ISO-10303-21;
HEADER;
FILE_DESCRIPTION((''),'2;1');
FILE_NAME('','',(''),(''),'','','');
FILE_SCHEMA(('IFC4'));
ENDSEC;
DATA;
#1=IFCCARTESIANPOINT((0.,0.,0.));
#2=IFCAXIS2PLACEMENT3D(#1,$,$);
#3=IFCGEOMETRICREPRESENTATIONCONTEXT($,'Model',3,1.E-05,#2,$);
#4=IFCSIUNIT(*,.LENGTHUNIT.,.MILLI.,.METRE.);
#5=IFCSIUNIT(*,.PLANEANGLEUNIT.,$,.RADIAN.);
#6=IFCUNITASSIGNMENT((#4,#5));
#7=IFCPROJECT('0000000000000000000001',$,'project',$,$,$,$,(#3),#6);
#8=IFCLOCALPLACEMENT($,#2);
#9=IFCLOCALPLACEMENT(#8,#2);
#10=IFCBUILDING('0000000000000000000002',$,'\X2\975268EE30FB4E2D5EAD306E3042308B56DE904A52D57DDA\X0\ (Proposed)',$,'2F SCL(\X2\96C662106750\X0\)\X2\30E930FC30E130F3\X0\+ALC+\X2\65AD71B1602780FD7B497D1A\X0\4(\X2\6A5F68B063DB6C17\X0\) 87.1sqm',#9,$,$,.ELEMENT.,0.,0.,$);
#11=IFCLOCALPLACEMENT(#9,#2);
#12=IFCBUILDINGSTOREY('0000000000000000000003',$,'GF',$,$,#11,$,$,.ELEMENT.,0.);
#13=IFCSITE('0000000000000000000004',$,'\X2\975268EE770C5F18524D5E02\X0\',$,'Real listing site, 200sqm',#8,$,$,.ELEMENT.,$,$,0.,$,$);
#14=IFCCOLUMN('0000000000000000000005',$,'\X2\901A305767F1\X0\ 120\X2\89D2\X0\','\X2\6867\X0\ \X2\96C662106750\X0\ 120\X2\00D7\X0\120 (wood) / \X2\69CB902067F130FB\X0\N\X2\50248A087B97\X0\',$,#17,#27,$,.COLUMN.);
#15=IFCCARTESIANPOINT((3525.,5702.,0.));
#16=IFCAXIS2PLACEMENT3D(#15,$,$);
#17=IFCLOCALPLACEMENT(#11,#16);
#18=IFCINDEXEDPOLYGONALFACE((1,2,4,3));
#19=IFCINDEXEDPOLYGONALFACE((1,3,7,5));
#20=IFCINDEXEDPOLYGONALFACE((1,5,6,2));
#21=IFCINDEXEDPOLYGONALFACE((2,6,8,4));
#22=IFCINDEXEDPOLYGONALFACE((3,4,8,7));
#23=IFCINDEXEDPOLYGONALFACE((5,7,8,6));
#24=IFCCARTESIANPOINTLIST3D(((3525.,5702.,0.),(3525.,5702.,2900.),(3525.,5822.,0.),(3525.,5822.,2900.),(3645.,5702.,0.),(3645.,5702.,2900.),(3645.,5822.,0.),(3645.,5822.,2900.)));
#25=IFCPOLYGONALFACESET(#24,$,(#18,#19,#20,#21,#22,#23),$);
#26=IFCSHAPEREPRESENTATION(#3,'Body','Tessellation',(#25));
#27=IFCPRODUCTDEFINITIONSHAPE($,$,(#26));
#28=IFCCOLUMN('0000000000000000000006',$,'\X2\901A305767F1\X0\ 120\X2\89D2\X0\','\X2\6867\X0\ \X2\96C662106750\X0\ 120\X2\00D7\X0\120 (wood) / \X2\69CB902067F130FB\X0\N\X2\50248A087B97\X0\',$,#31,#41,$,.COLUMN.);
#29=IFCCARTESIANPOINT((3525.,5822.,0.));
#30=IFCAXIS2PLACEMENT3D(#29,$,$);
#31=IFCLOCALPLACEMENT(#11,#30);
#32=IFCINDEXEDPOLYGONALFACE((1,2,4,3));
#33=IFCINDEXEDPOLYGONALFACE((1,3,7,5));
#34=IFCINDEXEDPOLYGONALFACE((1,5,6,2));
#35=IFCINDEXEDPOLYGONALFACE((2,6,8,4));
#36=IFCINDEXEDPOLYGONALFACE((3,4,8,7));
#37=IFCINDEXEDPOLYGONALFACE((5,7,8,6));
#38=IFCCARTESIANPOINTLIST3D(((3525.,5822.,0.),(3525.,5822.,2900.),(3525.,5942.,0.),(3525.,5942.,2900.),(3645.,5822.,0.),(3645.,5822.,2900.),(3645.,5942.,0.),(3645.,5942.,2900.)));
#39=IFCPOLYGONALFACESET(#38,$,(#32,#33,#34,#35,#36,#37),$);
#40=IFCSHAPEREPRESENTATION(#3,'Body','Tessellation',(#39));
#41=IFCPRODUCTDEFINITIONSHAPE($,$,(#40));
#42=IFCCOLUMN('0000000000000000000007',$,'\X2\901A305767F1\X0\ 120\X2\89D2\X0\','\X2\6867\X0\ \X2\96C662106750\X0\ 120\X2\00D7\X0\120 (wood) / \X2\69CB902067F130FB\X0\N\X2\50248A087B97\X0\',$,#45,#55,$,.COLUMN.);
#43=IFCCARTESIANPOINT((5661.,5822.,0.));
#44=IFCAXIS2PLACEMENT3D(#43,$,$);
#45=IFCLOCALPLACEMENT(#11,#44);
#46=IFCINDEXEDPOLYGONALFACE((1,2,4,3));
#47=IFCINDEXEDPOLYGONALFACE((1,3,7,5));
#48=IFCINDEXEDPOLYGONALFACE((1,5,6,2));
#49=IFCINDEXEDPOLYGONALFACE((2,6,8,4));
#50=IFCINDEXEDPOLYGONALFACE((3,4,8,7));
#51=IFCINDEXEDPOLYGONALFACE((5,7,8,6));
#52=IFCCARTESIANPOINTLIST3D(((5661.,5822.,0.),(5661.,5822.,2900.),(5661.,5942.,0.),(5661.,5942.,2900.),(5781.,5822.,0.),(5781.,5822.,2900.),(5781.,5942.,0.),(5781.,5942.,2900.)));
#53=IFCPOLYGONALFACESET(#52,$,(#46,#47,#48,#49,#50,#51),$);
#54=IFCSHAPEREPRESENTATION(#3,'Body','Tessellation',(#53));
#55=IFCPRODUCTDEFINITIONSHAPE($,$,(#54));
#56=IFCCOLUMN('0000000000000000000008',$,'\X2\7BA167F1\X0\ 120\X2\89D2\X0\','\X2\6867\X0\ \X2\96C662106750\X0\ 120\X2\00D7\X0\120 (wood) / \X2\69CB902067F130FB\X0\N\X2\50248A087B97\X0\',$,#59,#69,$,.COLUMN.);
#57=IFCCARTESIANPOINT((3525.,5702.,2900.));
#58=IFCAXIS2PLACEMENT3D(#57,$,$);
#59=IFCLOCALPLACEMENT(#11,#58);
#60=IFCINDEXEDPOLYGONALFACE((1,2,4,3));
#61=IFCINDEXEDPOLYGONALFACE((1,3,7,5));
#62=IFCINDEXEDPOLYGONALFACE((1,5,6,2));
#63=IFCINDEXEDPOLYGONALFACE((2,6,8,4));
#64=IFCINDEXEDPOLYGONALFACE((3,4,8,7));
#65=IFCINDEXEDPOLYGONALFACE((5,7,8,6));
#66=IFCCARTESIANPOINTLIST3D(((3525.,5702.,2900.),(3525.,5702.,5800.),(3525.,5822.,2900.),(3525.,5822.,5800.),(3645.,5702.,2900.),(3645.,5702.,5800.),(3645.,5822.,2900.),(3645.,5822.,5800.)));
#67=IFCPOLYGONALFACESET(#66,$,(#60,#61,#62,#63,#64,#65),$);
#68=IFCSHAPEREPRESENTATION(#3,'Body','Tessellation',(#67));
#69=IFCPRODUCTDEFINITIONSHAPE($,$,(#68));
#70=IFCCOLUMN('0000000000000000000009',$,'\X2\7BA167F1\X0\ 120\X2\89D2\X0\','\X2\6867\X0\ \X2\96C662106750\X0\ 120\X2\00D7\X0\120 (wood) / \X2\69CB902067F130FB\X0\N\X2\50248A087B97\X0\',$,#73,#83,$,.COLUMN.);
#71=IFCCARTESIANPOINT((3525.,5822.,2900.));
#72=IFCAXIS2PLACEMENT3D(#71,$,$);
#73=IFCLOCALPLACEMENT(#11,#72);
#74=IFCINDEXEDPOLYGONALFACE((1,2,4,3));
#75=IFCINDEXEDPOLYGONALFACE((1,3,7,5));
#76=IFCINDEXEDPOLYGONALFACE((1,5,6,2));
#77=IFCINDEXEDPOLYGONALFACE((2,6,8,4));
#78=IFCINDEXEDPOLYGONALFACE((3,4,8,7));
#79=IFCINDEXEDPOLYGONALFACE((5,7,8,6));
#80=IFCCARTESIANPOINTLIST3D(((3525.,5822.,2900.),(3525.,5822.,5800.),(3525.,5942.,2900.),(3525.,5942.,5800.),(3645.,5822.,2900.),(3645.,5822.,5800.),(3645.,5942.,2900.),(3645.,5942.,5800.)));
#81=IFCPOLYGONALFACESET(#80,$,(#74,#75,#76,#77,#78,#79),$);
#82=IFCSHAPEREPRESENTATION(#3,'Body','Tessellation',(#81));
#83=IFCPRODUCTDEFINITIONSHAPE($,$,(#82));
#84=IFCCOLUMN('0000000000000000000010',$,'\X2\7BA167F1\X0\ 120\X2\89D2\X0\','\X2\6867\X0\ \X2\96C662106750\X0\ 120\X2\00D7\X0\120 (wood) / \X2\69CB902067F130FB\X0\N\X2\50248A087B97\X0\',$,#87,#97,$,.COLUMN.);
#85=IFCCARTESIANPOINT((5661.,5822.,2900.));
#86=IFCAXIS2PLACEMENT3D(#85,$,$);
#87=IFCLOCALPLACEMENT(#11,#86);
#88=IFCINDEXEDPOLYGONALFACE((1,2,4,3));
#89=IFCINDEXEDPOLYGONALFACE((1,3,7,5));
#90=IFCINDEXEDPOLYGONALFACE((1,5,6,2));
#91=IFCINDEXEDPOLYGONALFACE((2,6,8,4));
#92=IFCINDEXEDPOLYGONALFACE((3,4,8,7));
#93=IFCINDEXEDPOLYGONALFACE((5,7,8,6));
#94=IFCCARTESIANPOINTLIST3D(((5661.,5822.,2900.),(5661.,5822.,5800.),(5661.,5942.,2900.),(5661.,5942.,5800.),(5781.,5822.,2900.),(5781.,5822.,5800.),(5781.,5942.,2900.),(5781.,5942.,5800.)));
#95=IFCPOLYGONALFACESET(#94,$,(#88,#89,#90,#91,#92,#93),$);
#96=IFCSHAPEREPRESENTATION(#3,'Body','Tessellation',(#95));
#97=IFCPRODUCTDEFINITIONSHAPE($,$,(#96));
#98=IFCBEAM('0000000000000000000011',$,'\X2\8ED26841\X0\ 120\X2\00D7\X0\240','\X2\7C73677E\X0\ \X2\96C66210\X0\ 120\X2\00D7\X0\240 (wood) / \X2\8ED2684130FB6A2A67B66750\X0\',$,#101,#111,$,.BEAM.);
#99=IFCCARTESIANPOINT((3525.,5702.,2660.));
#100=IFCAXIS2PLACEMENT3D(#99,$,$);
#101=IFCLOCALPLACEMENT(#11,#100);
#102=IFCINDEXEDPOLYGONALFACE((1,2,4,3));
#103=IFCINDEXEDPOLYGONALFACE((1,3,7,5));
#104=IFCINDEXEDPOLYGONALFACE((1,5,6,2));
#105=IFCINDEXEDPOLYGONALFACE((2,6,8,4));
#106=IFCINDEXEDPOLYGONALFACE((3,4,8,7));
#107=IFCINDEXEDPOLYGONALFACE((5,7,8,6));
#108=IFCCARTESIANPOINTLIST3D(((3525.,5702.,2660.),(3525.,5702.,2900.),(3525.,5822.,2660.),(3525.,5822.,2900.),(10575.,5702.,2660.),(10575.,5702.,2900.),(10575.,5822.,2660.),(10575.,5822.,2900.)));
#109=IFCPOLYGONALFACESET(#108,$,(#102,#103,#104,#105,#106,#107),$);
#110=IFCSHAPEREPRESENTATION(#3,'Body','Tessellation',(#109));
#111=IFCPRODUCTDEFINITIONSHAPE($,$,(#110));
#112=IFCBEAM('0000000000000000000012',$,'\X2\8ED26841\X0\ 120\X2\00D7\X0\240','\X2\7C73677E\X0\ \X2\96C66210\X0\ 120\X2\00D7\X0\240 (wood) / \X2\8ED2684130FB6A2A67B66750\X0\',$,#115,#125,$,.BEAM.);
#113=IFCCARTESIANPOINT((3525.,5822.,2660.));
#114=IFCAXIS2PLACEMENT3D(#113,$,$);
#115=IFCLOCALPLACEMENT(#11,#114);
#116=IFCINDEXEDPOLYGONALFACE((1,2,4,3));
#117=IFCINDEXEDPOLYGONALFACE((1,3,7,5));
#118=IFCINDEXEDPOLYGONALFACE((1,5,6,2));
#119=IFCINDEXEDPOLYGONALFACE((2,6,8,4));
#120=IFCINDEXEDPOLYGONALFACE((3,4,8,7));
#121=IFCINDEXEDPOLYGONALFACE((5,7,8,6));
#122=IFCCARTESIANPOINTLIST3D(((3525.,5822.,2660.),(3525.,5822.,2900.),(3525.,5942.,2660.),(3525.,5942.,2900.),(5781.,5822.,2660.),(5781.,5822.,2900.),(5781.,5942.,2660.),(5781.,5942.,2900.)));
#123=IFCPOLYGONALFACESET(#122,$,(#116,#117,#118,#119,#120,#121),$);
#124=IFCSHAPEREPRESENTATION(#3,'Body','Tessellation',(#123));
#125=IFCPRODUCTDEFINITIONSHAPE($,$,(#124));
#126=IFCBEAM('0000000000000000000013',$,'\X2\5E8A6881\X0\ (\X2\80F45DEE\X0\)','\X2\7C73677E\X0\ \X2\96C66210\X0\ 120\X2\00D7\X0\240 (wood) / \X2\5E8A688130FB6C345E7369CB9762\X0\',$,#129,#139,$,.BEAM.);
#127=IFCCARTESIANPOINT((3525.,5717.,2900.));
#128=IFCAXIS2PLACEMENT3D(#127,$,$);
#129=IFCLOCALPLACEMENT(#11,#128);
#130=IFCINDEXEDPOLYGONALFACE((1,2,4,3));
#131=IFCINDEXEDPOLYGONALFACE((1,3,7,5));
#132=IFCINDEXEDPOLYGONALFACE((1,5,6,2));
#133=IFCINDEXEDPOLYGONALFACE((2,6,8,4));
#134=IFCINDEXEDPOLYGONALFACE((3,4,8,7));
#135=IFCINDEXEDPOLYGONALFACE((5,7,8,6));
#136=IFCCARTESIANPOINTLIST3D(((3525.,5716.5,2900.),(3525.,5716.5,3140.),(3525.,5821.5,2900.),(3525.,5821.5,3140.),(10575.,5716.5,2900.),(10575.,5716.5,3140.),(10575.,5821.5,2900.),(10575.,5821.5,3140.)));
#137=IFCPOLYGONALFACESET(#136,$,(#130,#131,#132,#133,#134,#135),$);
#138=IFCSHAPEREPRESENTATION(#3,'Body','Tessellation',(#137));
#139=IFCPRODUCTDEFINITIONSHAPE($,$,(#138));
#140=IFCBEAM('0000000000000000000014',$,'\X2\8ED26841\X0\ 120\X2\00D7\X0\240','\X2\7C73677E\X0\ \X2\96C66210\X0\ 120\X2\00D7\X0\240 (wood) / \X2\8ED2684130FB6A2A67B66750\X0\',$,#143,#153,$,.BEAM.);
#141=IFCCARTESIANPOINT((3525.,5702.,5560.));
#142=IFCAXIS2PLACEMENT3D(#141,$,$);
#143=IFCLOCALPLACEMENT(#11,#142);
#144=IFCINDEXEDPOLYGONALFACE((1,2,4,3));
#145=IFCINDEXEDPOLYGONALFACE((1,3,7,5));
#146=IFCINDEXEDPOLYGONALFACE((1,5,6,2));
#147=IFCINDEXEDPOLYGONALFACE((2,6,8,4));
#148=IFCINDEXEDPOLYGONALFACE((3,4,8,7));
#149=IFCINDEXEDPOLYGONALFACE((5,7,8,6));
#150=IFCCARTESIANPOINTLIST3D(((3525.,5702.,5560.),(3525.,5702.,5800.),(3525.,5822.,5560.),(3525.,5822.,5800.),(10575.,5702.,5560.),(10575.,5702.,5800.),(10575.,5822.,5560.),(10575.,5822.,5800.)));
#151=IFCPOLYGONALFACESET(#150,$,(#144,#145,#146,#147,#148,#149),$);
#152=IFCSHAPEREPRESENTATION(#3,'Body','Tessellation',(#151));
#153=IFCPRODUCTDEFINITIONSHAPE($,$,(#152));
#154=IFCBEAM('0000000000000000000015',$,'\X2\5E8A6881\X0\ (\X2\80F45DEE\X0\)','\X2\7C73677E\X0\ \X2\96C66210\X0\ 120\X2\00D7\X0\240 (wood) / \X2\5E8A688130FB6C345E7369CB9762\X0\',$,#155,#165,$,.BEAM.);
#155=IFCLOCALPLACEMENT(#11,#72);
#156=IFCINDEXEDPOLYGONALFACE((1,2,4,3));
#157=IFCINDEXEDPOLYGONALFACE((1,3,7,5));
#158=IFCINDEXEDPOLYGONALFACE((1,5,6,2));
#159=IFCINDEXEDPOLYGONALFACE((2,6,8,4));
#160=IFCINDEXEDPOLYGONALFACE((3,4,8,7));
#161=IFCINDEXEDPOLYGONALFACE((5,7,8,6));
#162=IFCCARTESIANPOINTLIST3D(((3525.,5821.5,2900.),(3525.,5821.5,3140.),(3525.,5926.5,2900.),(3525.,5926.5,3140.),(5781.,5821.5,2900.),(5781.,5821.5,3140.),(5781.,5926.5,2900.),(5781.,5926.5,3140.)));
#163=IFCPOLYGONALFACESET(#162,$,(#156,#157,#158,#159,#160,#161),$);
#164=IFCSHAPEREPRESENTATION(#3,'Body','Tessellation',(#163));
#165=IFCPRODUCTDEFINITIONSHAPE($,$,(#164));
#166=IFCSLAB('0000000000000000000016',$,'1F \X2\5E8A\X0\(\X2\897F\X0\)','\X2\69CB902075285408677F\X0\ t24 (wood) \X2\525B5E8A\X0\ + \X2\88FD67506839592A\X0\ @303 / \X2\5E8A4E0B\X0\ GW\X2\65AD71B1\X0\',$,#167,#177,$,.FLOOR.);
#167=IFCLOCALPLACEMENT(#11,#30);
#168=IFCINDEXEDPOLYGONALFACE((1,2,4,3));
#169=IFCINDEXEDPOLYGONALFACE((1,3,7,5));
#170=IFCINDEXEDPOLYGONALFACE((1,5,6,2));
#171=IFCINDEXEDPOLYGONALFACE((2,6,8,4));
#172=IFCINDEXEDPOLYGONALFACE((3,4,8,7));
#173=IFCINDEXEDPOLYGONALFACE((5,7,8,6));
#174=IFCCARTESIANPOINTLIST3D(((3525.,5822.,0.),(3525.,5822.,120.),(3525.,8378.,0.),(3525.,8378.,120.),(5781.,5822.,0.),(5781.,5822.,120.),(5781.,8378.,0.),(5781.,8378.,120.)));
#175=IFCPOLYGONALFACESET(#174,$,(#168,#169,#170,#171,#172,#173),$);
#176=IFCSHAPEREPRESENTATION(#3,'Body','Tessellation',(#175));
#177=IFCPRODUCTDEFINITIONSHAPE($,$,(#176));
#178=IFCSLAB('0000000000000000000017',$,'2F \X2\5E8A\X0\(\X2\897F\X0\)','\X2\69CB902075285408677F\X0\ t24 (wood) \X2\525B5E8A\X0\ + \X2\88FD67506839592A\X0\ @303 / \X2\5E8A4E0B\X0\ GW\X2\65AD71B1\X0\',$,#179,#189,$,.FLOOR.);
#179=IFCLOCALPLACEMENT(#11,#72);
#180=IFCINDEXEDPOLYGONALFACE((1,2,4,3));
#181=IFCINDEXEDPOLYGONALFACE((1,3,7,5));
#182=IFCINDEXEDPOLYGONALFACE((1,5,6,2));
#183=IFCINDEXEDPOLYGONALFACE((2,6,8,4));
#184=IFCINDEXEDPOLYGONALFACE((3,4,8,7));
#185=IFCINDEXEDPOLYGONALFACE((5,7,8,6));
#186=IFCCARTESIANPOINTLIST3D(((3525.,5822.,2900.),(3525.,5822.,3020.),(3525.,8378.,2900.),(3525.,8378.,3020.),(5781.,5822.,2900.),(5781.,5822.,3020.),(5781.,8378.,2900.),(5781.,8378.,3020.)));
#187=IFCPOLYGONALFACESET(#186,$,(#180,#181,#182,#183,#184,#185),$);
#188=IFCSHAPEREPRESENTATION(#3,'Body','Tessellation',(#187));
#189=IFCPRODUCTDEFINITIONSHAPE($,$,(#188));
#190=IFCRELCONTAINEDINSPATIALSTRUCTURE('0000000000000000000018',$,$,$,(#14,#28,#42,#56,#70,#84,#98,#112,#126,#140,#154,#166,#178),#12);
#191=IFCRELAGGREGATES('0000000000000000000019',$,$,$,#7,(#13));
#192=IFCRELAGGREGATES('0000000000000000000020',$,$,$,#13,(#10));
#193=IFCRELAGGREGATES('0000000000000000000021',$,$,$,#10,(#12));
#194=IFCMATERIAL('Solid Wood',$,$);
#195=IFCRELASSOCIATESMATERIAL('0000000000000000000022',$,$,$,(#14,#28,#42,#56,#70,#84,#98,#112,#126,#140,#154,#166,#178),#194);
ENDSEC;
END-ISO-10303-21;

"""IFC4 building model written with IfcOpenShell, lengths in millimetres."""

from ifc_helpers import new_model, si_unit, frame, frame_2d, origin, place, context, project, spatial, rectangle, extrude, material, element, save


model = new_model("IFC4")

# Units and contexts
model_context = context("Model", 3, precision=1e-05, world=origin())
ifc_project = project(units=[si_unit("LENGTHUNIT", "METRE", prefix="MILLI"), si_unit("PLANEANGLEUNIT", "RADIAN")], contexts=[model_context])

# Site, building, storey
site_placement = place(None, origin())
site = spatial("IfcSite", under=ifc_project, at=site_placement, Name="青森県弘前市", ObjectType="Real listing site, 200sqm", CompositionType="ELEMENT", RefElevation=0.0)
building_placement = place(site_placement, origin())
building = spatial("IfcBuilding", under=site, at=building_placement, Name="青森・中庭のある回遊動線 (Proposed)", ObjectType="2F SCL(集成材)ラーメン+ALC+断熱性能等級4(機械換気) 87.1sqm", CompositionType="ELEMENT", ElevationOfRefHeight=0.0, ElevationOfTerrain=0.0)
storey_placement = place(building_placement, origin())
storey = spatial("IfcBuildingStorey", under=building, at=storey_placement, Name="GF", CompositionType="ELEMENT", Elevation=0.0)

# Columns
ifc_material_1 = material(Name="Solid Wood")
column_1_placement = place(storey_placement, frame((3525.0, 5702.0, 0.0)))
element("IfcColumn", 1, at=column_1_placement, inside=storey, material=ifc_material_1, Name="通し柱 120角", Description="桧 集成材 120×120 (wood) / 構造柱・N値計算", PredefinedType="COLUMN", context=model_context, shape_type="SweptSolid", body=[
    extrude(rectangle(XDim=120.0, YDim=120.0, at=frame_2d((60.0, 60.0))), frame((3525.0, 5702.0, 0.0)), (0.0, 0.0, 1.0), 2900.0),
])
column_2_placement = place(storey_placement, frame((3525.0, 5822.0, 0.0)))
element("IfcColumn", 2, at=column_2_placement, inside=storey, material=ifc_material_1, Name="通し柱 120角", Description="桧 集成材 120×120 (wood) / 構造柱・N値計算", PredefinedType="COLUMN", context=model_context, shape_type="SweptSolid", body=[
    extrude(rectangle(XDim=120.0, YDim=120.0, at=frame_2d((60.0, 60.0))), frame((3525.0, 5822.0, 0.0)), (0.0, 0.0, 1.0), 2900.0),
])
column_3_placement = place(storey_placement, frame((5661.0, 5822.0, 0.0)))
element("IfcColumn", 3, at=column_3_placement, inside=storey, material=ifc_material_1, Name="通し柱 120角", Description="桧 集成材 120×120 (wood) / 構造柱・N値計算", PredefinedType="COLUMN", context=model_context, shape_type="SweptSolid", body=[
    extrude(rectangle(XDim=120.0, YDim=120.0, at=frame_2d((60.0, 60.0))), frame((5661.0, 5822.0, 0.0)), (0.0, 0.0, 1.0), 2900.0),
])
column_4_placement = place(storey_placement, frame((3525.0, 5702.0, 2900.0)))
element("IfcColumn", 4, at=column_4_placement, inside=storey, material=ifc_material_1, Name="管柱 120角", Description="桧 集成材 120×120 (wood) / 構造柱・N値計算", PredefinedType="COLUMN", context=model_context, shape_type="SweptSolid", body=[
    extrude(rectangle(XDim=120.0, YDim=120.0, at=frame_2d((60.0, 60.0))), frame((3525.0, 5702.0, 2900.0)), (0.0, 0.0, 1.0), 2900.0),
])
column_5_placement = place(storey_placement, frame((3525.0, 5822.0, 2900.0)))
element("IfcColumn", 5, at=column_5_placement, inside=storey, material=ifc_material_1, Name="管柱 120角", Description="桧 集成材 120×120 (wood) / 構造柱・N値計算", PredefinedType="COLUMN", context=model_context, shape_type="SweptSolid", body=[
    extrude(rectangle(XDim=120.0, YDim=120.0, at=frame_2d((60.0, 60.0))), frame((3525.0, 5822.0, 2900.0)), (0.0, 0.0, 1.0), 2900.0),
])
column_6_placement = place(storey_placement, frame((5661.0, 5822.0, 2900.0)))
element("IfcColumn", 6, at=column_6_placement, inside=storey, material=ifc_material_1, Name="管柱 120角", Description="桧 集成材 120×120 (wood) / 構造柱・N値計算", PredefinedType="COLUMN", context=model_context, shape_type="SweptSolid", body=[
    extrude(rectangle(XDim=120.0, YDim=120.0, at=frame_2d((60.0, 60.0))), frame((5661.0, 5822.0, 2900.0)), (0.0, 0.0, 1.0), 2900.0),
])

# Beams
beam_1_placement = place(storey_placement, frame((3525.0, 5702.0, 2660.0)))
element("IfcBeam", 7, at=beam_1_placement, inside=storey, material=ifc_material_1, Name="軒桁 120×240", Description="米松 集成 120×240 (wood) / 軒桁・横架材", PredefinedType="BEAM", context=model_context, shape_type="SweptSolid", body=[
    extrude(rectangle(XDim=7050.0, YDim=120.0, at=frame_2d((3525.0, 60.0))), frame((3525.0, 5702.0, 2660.0)), (0.0, 0.0, 1.0), 240.0),
])
beam_2_placement = place(storey_placement, frame((3525.0, 5822.0, 2660.0)))
element("IfcBeam", 8, at=beam_2_placement, inside=storey, material=ifc_material_1, Name="軒桁 120×240", Description="米松 集成 120×240 (wood) / 軒桁・横架材", PredefinedType="BEAM", context=model_context, shape_type="SweptSolid", body=[
    extrude(rectangle(XDim=2256.0, YDim=120.0, at=frame_2d((1128.0, 60.0))), frame((3525.0, 5822.0, 2660.0)), (0.0, 0.0, 1.0), 240.0),
])
beam_3_placement = place(storey_placement, frame((3525.0, 5717.0, 2900.0)))
element("IfcBeam", 9, at=beam_3_placement, inside=storey, material=ifc_material_1, Name="床梁 (胴差)", Description="米松 集成 120×240 (wood) / 床梁・水平構面", PredefinedType="BEAM", context=model_context, shape_type="SweptSolid", body=[
    extrude(rectangle(XDim=7050.0, YDim=105.0, at=frame_2d((3525.0, 52.0))), frame((3525.0, 5717.0, 2900.0)), (0.0, 0.0, 1.0), 240.0),
])
beam_4_placement = place(storey_placement, frame((3525.0, 5702.0, 5560.0)))
element("IfcBeam", 10, at=beam_4_placement, inside=storey, material=ifc_material_1, Name="軒桁 120×240", Description="米松 集成 120×240 (wood) / 軒桁・横架材", PredefinedType="BEAM", context=model_context, shape_type="SweptSolid", body=[
    extrude(rectangle(XDim=7050.0, YDim=120.0, at=frame_2d((3525.0, 60.0))), frame((3525.0, 5702.0, 5560.0)), (0.0, 0.0, 1.0), 240.0),
])
beam_5_placement = place(storey_placement, frame((3525.0, 5822.0, 2900.0)))
element("IfcBeam", 11, at=beam_5_placement, inside=storey, material=ifc_material_1, Name="床梁 (胴差)", Description="米松 集成 120×240 (wood) / 床梁・水平構面", PredefinedType="BEAM", context=model_context, shape_type="SweptSolid", body=[
    extrude(rectangle(XDim=2256.0, YDim=105.0, at=frame_2d((1128.0, 52.0))), frame((3525.0, 5822.0, 2900.0)), (0.0, 0.0, 1.0), 240.0),
])

# Slabs
slab_1_placement = place(storey_placement, frame((3525.0, 5822.0, 0.0)))
element("IfcSlab", 12, at=slab_1_placement, inside=storey, material=ifc_material_1, Name="1F 床(西)", Description="構造用合板 t24 (wood) 剛床 + 製材根太 @303 / 床下 GW断熱", PredefinedType="FLOOR", context=model_context, shape_type="SweptSolid", body=[
    extrude(rectangle(XDim=2256.0, YDim=2556.0, at=frame_2d((1128.0, 1278.0))), frame((3525.0, 5822.0, 0.0)), (0.0, 0.0, 1.0), 120.0),
])
slab_2_placement = place(storey_placement, frame((3525.0, 5822.0, 2900.0)))
element("IfcSlab", 13, at=slab_2_placement, inside=storey, material=ifc_material_1, Name="2F 床(西)", Description="構造用合板 t24 (wood) 剛床 + 製材根太 @303 / 床下 GW断熱", PredefinedType="FLOOR", context=model_context, shape_type="SweptSolid", body=[
    extrude(rectangle(XDim=2256.0, YDim=2556.0, at=frame_2d((1128.0, 1278.0))), frame((3525.0, 5822.0, 2900.0)), (0.0, 0.0, 1.0), 120.0),
])

save(model, "model.ifc")
